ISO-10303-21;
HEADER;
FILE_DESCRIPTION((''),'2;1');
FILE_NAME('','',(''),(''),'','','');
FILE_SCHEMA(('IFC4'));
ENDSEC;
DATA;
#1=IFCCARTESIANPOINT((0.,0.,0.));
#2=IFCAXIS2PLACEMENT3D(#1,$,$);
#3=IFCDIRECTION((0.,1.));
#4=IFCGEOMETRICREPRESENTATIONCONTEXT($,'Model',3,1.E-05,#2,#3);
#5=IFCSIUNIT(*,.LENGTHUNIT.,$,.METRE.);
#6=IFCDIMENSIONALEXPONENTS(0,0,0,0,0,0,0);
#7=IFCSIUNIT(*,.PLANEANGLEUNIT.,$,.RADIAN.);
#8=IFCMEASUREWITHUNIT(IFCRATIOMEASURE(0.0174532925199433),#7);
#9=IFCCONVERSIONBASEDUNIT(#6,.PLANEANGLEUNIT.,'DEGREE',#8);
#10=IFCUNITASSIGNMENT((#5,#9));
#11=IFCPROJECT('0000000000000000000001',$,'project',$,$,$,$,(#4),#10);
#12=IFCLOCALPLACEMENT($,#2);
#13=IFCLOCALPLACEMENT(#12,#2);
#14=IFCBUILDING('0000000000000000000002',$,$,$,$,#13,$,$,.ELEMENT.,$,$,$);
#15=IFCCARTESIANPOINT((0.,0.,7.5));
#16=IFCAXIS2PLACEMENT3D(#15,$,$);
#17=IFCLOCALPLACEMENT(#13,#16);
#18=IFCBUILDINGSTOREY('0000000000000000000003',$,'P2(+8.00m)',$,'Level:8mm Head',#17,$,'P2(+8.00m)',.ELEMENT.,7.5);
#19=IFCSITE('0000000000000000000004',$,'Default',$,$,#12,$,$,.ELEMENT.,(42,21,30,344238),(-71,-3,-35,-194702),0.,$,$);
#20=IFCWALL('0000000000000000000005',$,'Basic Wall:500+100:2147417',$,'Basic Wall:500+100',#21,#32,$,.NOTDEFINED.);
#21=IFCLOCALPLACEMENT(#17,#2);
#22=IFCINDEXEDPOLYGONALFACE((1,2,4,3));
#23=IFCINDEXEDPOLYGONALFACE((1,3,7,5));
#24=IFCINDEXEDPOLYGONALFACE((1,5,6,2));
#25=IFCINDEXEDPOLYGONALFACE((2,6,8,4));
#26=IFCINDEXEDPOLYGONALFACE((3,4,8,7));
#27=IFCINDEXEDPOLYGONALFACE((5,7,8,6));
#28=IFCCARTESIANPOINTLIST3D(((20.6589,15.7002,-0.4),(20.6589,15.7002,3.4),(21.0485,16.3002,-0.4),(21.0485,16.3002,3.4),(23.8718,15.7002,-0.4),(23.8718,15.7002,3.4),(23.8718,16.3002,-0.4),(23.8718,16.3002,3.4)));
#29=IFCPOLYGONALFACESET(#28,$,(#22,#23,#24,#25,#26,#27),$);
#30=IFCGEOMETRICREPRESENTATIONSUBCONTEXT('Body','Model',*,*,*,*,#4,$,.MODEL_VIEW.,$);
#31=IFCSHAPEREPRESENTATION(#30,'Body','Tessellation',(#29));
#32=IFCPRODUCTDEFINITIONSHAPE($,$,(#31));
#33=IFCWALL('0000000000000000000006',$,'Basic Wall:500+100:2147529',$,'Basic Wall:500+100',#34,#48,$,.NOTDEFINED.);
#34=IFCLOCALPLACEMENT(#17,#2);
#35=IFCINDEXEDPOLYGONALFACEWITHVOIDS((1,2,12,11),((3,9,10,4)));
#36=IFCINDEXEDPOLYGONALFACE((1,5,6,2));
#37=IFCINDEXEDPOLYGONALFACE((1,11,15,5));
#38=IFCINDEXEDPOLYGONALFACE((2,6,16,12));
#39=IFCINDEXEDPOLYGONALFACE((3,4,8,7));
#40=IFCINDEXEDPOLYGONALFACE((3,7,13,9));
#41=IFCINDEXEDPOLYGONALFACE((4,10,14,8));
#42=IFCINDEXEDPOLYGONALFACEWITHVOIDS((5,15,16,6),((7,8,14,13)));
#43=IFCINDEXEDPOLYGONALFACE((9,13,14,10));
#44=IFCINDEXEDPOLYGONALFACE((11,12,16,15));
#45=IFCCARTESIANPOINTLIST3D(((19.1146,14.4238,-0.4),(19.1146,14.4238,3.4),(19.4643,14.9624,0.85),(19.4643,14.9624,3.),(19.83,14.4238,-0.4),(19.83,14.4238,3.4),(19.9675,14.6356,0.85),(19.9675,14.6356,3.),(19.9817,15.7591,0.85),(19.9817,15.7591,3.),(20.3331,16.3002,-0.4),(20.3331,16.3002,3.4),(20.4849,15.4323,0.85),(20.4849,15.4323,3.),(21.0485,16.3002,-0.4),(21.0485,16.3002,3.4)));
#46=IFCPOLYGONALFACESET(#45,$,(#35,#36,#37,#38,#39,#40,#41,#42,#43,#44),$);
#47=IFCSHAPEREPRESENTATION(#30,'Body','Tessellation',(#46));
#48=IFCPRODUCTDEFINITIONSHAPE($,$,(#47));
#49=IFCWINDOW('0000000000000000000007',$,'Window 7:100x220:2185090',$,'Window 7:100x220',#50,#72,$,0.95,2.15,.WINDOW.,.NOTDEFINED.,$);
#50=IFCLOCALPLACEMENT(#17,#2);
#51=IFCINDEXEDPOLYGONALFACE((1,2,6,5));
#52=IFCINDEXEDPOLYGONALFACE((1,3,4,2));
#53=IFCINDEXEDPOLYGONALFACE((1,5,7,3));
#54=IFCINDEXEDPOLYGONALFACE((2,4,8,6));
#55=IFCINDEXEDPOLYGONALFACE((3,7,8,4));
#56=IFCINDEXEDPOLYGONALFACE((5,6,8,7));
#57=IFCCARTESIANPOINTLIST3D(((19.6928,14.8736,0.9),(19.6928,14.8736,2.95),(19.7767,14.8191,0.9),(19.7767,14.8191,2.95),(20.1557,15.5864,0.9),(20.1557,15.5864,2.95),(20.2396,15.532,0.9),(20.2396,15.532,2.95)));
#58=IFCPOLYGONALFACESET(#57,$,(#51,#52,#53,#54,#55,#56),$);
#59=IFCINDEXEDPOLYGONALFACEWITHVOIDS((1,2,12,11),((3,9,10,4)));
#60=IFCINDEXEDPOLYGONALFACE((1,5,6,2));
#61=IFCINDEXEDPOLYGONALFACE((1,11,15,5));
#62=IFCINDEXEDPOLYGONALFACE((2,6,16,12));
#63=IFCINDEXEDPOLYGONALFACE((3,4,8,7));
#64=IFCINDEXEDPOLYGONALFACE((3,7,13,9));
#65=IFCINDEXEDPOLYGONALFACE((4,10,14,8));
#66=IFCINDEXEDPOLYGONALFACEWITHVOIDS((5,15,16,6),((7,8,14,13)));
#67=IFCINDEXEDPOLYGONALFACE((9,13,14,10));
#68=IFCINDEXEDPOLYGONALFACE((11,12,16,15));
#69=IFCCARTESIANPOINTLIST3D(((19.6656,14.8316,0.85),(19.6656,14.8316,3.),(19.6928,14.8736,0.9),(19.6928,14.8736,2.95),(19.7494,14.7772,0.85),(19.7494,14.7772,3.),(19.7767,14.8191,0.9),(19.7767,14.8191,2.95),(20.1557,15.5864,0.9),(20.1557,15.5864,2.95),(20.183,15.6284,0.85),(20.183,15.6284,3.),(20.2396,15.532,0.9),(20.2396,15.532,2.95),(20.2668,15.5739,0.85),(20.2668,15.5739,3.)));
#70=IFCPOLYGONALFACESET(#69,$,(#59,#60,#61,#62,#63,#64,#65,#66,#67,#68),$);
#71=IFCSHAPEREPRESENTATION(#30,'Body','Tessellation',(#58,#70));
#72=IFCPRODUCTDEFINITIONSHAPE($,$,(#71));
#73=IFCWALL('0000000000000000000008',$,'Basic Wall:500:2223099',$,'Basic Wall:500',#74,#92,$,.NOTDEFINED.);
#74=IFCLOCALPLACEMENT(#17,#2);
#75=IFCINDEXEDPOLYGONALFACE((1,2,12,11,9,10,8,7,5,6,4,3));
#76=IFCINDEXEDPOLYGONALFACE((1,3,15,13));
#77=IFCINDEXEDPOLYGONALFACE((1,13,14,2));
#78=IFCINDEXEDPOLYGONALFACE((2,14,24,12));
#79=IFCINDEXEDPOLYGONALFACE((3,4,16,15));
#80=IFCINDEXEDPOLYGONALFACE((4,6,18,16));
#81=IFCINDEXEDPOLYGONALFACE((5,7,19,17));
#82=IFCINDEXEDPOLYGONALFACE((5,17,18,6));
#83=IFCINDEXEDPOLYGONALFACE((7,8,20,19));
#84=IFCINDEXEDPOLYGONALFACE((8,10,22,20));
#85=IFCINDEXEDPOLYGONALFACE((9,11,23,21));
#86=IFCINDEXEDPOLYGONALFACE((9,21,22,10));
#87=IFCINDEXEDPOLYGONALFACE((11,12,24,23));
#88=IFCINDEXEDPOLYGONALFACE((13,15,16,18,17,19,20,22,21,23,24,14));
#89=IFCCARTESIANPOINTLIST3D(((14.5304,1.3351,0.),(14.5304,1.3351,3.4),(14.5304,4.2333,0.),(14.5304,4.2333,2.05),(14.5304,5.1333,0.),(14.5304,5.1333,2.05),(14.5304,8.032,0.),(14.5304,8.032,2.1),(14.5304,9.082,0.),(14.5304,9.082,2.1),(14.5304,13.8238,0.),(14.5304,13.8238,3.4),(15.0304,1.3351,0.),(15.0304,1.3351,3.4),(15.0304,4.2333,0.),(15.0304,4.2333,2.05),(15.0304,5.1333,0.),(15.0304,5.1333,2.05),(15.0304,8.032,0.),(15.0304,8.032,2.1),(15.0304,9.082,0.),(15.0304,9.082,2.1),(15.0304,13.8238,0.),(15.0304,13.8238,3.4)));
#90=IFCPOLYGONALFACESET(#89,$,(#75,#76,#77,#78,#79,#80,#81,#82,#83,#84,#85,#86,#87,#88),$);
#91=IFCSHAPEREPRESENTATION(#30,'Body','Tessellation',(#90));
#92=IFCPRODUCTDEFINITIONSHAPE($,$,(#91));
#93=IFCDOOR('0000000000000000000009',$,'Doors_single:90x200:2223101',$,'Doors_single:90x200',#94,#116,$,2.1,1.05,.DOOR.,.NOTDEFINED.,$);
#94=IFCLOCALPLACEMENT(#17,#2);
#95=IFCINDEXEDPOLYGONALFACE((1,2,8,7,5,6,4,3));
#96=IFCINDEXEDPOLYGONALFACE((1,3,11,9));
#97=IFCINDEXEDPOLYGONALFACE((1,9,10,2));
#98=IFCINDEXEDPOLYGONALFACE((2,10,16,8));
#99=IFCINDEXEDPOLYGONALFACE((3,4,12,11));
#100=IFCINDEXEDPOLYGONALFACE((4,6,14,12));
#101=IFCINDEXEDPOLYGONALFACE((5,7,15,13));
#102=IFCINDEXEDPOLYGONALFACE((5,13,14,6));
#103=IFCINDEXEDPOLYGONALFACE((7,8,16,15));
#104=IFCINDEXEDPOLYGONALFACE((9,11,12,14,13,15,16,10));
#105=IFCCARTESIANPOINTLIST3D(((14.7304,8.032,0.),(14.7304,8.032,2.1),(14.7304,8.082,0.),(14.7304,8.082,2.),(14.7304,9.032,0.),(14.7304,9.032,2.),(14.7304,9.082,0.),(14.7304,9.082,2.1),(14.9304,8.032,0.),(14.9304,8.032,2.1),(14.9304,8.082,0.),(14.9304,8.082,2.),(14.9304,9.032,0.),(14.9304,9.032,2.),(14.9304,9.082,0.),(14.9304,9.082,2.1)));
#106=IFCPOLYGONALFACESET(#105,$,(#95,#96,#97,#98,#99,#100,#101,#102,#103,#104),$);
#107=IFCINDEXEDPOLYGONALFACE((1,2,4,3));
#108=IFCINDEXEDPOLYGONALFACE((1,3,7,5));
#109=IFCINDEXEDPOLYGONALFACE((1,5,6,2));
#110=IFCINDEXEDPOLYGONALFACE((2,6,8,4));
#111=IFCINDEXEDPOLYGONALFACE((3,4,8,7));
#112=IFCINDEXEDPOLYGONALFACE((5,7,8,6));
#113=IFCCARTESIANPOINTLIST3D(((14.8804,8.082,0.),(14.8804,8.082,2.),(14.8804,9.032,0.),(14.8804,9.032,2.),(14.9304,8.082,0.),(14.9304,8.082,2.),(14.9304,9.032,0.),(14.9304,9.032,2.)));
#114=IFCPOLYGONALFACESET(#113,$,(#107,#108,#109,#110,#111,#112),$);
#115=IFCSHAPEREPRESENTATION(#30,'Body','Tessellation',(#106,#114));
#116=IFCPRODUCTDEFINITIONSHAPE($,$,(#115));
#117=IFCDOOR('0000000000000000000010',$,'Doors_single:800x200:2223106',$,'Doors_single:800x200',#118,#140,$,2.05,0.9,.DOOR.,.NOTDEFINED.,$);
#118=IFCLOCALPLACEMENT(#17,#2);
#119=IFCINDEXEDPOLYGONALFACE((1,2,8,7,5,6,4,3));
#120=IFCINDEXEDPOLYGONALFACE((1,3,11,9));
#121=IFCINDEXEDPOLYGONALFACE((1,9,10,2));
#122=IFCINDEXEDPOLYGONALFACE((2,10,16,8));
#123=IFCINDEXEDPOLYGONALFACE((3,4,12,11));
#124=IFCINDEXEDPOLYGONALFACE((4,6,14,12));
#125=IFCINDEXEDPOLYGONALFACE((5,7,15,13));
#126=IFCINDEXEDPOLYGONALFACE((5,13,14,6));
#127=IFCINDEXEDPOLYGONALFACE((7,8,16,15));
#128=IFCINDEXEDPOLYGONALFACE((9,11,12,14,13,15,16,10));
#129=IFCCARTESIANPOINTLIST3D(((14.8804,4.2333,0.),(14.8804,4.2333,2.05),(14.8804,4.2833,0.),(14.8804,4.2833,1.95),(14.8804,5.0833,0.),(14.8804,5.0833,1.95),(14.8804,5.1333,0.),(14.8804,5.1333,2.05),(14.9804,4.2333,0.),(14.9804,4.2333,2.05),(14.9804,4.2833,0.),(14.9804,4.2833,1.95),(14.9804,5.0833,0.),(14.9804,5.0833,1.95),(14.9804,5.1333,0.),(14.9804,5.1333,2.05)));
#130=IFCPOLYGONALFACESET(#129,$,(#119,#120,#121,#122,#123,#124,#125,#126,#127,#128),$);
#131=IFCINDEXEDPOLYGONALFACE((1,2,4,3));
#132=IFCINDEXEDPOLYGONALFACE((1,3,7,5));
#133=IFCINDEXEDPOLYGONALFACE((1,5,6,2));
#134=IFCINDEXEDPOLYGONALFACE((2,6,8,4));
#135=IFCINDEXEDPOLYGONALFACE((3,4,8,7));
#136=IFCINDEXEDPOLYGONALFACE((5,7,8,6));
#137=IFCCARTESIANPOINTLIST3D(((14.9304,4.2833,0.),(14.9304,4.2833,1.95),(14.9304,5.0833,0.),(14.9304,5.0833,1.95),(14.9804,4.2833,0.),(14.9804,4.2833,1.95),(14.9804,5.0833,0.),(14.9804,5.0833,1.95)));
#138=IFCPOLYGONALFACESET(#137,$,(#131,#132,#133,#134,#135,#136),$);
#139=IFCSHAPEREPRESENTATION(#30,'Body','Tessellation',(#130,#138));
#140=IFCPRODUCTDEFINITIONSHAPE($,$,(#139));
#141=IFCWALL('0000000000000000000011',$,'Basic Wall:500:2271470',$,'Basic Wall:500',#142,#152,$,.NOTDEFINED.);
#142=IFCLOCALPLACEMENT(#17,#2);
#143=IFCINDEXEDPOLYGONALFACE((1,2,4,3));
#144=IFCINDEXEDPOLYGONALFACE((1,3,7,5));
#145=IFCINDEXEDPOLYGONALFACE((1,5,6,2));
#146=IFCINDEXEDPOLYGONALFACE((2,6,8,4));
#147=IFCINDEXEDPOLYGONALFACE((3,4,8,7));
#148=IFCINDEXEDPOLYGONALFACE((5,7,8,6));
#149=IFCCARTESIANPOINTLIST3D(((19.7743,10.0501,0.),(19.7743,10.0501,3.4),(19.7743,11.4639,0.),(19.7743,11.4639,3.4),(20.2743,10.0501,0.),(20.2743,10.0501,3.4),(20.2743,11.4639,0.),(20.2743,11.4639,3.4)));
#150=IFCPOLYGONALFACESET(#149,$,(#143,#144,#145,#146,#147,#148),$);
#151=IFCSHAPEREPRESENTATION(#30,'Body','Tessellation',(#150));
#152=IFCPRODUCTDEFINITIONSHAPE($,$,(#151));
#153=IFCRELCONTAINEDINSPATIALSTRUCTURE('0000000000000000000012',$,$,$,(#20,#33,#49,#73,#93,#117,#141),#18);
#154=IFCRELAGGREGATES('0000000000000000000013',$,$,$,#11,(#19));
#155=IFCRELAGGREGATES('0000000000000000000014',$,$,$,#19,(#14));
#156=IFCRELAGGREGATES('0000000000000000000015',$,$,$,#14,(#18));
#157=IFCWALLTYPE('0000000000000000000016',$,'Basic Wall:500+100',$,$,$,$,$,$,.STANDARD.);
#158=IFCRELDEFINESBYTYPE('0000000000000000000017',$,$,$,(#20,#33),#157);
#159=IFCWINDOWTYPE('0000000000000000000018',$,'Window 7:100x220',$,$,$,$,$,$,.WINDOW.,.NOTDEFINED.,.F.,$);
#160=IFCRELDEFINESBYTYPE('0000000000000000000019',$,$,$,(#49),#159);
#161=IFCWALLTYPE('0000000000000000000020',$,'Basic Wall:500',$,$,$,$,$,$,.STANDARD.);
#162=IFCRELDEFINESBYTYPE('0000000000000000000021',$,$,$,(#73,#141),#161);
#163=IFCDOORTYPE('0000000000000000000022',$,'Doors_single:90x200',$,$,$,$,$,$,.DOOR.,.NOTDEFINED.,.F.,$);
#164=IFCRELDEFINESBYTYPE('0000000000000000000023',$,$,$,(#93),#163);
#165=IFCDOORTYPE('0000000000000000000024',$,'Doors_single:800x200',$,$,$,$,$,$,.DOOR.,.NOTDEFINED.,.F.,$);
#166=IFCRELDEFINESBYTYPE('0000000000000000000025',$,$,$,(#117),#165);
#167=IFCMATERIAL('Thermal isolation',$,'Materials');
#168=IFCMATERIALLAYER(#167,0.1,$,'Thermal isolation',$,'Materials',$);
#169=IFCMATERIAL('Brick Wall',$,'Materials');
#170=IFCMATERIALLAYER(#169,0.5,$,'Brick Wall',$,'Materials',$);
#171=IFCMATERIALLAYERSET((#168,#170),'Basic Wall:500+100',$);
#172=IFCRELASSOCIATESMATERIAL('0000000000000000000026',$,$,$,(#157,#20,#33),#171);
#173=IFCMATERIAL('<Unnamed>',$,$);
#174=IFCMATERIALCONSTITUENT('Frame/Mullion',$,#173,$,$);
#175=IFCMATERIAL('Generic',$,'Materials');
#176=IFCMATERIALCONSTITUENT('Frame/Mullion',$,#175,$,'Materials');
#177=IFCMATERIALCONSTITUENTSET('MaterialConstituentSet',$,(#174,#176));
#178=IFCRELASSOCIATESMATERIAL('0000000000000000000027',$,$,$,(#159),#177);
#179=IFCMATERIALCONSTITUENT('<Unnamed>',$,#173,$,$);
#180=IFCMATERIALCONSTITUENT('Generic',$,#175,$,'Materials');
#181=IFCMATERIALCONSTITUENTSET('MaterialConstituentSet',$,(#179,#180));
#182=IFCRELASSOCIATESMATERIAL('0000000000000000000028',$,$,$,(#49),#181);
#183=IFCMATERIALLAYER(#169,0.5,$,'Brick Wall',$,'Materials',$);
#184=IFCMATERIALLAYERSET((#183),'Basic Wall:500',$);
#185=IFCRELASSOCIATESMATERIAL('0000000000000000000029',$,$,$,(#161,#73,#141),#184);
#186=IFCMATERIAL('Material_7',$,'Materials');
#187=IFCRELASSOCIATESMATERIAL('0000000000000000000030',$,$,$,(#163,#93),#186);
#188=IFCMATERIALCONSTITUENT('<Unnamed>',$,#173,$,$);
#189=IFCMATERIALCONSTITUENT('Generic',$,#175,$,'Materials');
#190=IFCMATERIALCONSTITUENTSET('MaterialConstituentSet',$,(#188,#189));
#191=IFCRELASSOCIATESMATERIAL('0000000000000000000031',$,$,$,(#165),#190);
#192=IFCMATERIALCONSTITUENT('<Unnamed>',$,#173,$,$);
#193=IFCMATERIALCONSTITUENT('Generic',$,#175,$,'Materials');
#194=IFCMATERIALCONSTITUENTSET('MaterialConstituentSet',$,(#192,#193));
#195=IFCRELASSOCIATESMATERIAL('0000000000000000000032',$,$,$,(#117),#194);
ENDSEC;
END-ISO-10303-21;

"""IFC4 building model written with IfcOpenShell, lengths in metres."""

from ifc_helpers import new_model, entity, si_unit, converted_unit, direction, frame, frame_2d, origin, origin_2d_with_axis, place, context, subcontext, project, spatial, polyline, rectangle, outline, extrude, source, transform, mapped, material, layer, layer_set, layer_usage, constituent, constituent_set, type_object, type_shapes, element, fill, save


model = new_model("IFC4")

# Units and contexts
model_context = context("Model", 3, precision=1e-05, world=origin(), true_north=direction((0.0, 1.0)))
body_context = subcontext(model_context, "Body", "Model", "MODEL_VIEW")
ifc_project = project(units=[si_unit("LENGTHUNIT", "METRE"), converted_unit("PLANEANGLEUNIT", "DEGREE", entity("IfcRatioMeasure", 0.0174532925199433), si_unit("PLANEANGLEUNIT", "RADIAN"), dimensions=[0, 0, 0, 0, 0, 0, 0])], contexts=[model_context])

# Site, building, storey
site_placement = place(None, origin())
site = spatial("IfcSite", under=ifc_project, at=site_placement, Name="Default", CompositionType="ELEMENT", RefLatitude=(42, 21, 30, 344238), RefLongitude=(-71, -3, -35, -194702), RefElevation=0.0)
building_placement = place(site_placement, origin())
building = spatial("IfcBuilding", under=site, at=building_placement, CompositionType="ELEMENT")
storey_placement = place(building_placement, frame((0.0, 0.0, 7.5)))
storey = spatial("IfcBuildingStorey", under=building, at=storey_placement, Name="P2(+8.00m)", ObjectType="Level:8mm Head", LongName="P2(+8.00m)", CompositionType="ELEMENT", Elevation=7.5)

# Wall
ifc_material_1 = material(Name="Thermal isolation", Category="Materials")
ifc_layer_1 = layer(ifc_material_1, 0.1, Name="Thermal isolation", Category="Materials")
ifc_material_2 = material(Name="Brick Wall", Category="Materials")
ifc_layer_2 = layer(ifc_material_2, 0.5, Name="Brick Wall", Category="Materials")
ifc_layer_set_1 = layer_set([ifc_layer_1, ifc_layer_2], Name="Basic Wall:500+100")
ifc_layer_usage_1 = layer_usage(ifc_layer_set_1, "AXIS2", "POSITIVE", -0.3)
wall_type_1 = type_object("IfcWallType", Name="Basic Wall:500+100", PredefinedType="STANDARD", material=ifc_layer_set_1)
wall_1_placement = place(storey_placement, frame((23.8718, 16.0002, -0.4), z_axis=(0.0, 0.0, 1.0), x_axis=(-1.0, 0.0, 0.0)))
element("IfcWall", 1, at=wall_1_placement, inside=storey, type_object=wall_type_1, material=ifc_layer_usage_1, Name="Basic Wall:500+100:2147417", ObjectType="Basic Wall:500+100", PredefinedType="NOTDEFINED", context=body_context, shape_type="SweptSolid", body=[
    extrude(outline(polyline([(2.8233, -0.3), (3.213, 0.3), (0.0, 0.3), (0.0, -0.3), (2.8233, -0.3)])), origin(), (0.0, 0.0, 1.0), 3.8),
])

# Wall, opening, window
ifc_layer_usage_2 = layer_usage(ifc_layer_set_1, "AXIS2", "NEGATIVE", 0.3)
wall_2_placement = place(storey_placement, frame((19.3662, 14.2604, -0.4), z_axis=(0.0, 0.0, 1.0), x_axis=(0.544639, 0.838671, 0.0)))
wall_2 = element("IfcWall", 2, at=wall_2_placement, inside=storey, type_object=wall_type_1, material=ifc_layer_usage_2, Name="Basic Wall:500+100:2147529", ObjectType="Basic Wall:500+100", PredefinedType="NOTDEFINED", context=body_context, shape_type="SweptSolid", body=[
    extrude(outline(polyline([(2.627, -0.3), (2.2373, 0.3), (0.0, 0.3), (0.3896, -0.3), (1.9115, -0.3), (2.627, -0.3)])), origin(), (0.0, 0.0, 1.0), 3.8),
])
opening_1_placement = place(wall_2_placement, frame((0.0702, 0.3278, 1.25), z_axis=(0.0, 0.0, 1.0), x_axis=(0.544639, -0.838671, 0.0)))
opening_1 = element("IfcOpeningElement", 3, at=opening_1_placement, cuts=wall_2, PredefinedType="OPENING", context=body_context, shape_type="SweptSolid", body=[
    extrude(rectangle(XDim=2.15, YDim=0.95, at=frame_2d((0.0, 0.0), x_axis=(1.0, 0.0))), frame((1.3087, 0.3984, 1.075), z_axis=(-0.838671, 0.544639, 0.0), x_axis=(0.0, 0.0, -1.0)), (0.0, 0.0, 1.0), 1.252),
])
ifc_material_3 = material(Name="<Unnamed>")
ifc_constituent_1 = constituent(ifc_material_3, Name="<Unnamed>")
ifc_material_4 = material(Name="Generic", Category="Materials")
ifc_constituent_2 = constituent(ifc_material_4, Name="Generic", Category="Materials")
ifc_constituent_set_1 = constituent_set(constituents=[ifc_constituent_1, ifc_constituent_2], Name="MaterialConstituentSet")
ifc_constituent_3 = constituent(ifc_material_3, Name="Frame/Mullion")
ifc_constituent_4 = constituent(ifc_material_4, Name="Frame/Mullion", Category="Materials")
ifc_constituent_set_2 = constituent_set(constituents=[ifc_constituent_3, ifc_constituent_4], Name="MaterialConstituentSet")
window_type = type_object("IfcWindowType", Name="Window 7:100x220", ParameterTakesPrecedence=False, PartitioningType="NOTDEFINED", PredefinedType="WINDOW", material=ifc_constituent_set_2)
shared_shape_1 = source(origin(), body_context, "Body", "SweptSolid", [
    extrude(rectangle(XDim=0.1, YDim=0.85, at=origin_2d_with_axis()), frame((0.475, -0.6891, 0.05), z_axis=(0.0, 0.0, 1.0), x_axis=(0.0, 1.0, 0.0)), (0.0, 0.0, 1.0), 2.05),
    extrude(outline(polyline([(-0.475, -1.075), (0.475, -1.075), (0.475, 1.075), (-0.475, 1.075), (-0.475, -1.075)]), holes=[polyline([(-0.425, -1.025), (-0.425, 1.025), (0.425, 1.025), (0.425, -1.025), (-0.425, -1.025)])]), frame((0.475, -0.7391, 1.075), z_axis=(0.0, 1.0, 0.0), x_axis=(1.0, 0.0, 0.0)), (0.0, 0.0, 1.0), 0.1),
])
type_shapes(window_type, [shared_shape_1])
window_placement = place(opening_1_placement, frame((0.0, 0.6819, 0.0), z_axis=(0.0, 0.0, 1.0), x_axis=(0.544639, 0.838671, 0.0)))
window = element("IfcWindow", 4, at=window_placement, inside=storey, type_object=window_type, material=ifc_constituent_set_1, Name="Window 7:100x220:2185090", ObjectType="Window 7:100x220", OverallHeight=0.95, OverallWidth=2.15, PartitioningType="NOTDEFINED", PredefinedType="WINDOW", context=body_context, shape_type="MappedRepresentation", body=[
    mapped(shared_shape_1, transform((0.0, 0.0, 0.0), scale=1.0)),
])
fill(opening_1, window)

# Wall, openings, doors
ifc_layer_3 = layer(ifc_material_2, 0.5, Name="Brick Wall", Category="Materials")
ifc_layer_set_2 = layer_set([ifc_layer_3], Name="Basic Wall:500")
ifc_layer_usage_3 = layer_usage(ifc_layer_set_2, "AXIS2", "POSITIVE", -0.25)
wall_type_2 = type_object("IfcWallType", Name="Basic Wall:500", PredefinedType="STANDARD", material=ifc_layer_set_2)
wall_3_placement = place(storey_placement, frame((14.7804, 13.8238, 0.0), z_axis=(0.0, 0.0, 1.0), x_axis=(0.0, -1.0, 0.0)))
wall_3 = element("IfcWall", 5, at=wall_3_placement, inside=storey, type_object=wall_type_2, material=ifc_layer_usage_3, Name="Basic Wall:500:2223099", ObjectType="Basic Wall:500", PredefinedType="NOTDEFINED", context=body_context, shape_type="SweptSolid", body=[
    extrude(rectangle(XDim=12.4888, YDim=0.5, at=frame_2d((6.2444, 0.0), x_axis=(-1.0, 0.0))), origin(), (0.0, 0.0, 1.0), 3.4),
])
opening_2_placement = place(wall_3_placement, frame((8.6906, -0.25, 0.0)))
opening_2 = element("IfcOpeningElement", 6, at=opening_2_placement, cuts=wall_3, PredefinedType="OPENING", context=body_context, shape_type="SweptSolid", body=[
    extrude(rectangle(XDim=2.05, YDim=0.9, at=frame_2d((1.025, 0.45), x_axis=(1.0, 0.0))), frame((0.0, 0.0, 0.0), z_axis=(0.0, 1.0, 0.0), x_axis=(0.0, 0.0, 1.0)), (0.0, 0.0, 1.0), 0.5),
])
opening_3_placement = place(wall_3_placement, frame((4.7418, -0.25, 0.0)))
opening_3 = element("IfcOpeningElement", 7, at=opening_3_placement, cuts=wall_3, PredefinedType="OPENING", context=body_context, shape_type="SweptSolid", body=[
    extrude(rectangle(XDim=2.1, YDim=1.05, at=frame_2d((1.05, 0.525), x_axis=(1.0, 0.0))), frame((0.0, 0.0, 0.0), z_axis=(0.0, 1.0, 0.0), x_axis=(0.0, 0.0, 1.0)), (0.0, 0.0, 1.0), 0.5),
])
ifc_material_5 = material(Name="Material_7", Category="Materials")
door_type_1 = type_object("IfcDoorType", Name="Doors_single:90x200", OperationType="NOTDEFINED", ParameterTakesPrecedence=False, PredefinedType="DOOR", material=ifc_material_5)
shared_shape_2 = source(origin(), body_context, "Body", "SweptSolid", [
    extrude(outline(polyline([(-0.525, -1.025), (-0.475, -1.025), (-0.475, 0.975), (0.475, 0.975), (0.475, -1.025), (0.525, -1.025), (0.525, 1.075), (-0.525, 1.075), (-0.525, -1.025)])), frame((0.525, 0.4, 1.025), z_axis=(0.0, -1.0, 0.0), x_axis=(1.0, 0.0, 0.0)), (0.0, 0.0, 1.0), 0.2),
    extrude(rectangle(XDim=0.05, YDim=0.95, at=origin_2d_with_axis()), frame((0.525, 0.375, 0.0), z_axis=(0.0, 0.0, 1.0), x_axis=(0.0, -1.0, 0.0)), (0.0, 0.0, 1.0), 2.0),
])
type_shapes(door_type_1, [shared_shape_2])
door_1_placement = place(opening_3_placement, origin())
door_1 = element("IfcDoor", 8, at=door_1_placement, inside=storey, type_object=door_type_1, material=ifc_material_5, Name="Doors_single:90x200:2223101", ObjectType="Doors_single:90x200", OperationType="NOTDEFINED", OverallHeight=2.1, OverallWidth=1.05, PredefinedType="DOOR", context=body_context, shape_type="MappedRepresentation", body=[
    mapped(shared_shape_2, transform((0.0, 0.0, 0.0), scale=1.0)),
])
fill(opening_3, door_1)
ifc_constituent_5 = constituent(ifc_material_3, Name="<Unnamed>")
ifc_constituent_6 = constituent(ifc_material_4, Name="Generic", Category="Materials")
ifc_constituent_set_3 = constituent_set(constituents=[ifc_constituent_5, ifc_constituent_6], Name="MaterialConstituentSet")
ifc_constituent_7 = constituent(ifc_material_3, Name="<Unnamed>")
ifc_constituent_8 = constituent(ifc_material_4, Name="Generic", Category="Materials")
ifc_constituent_set_4 = constituent_set(constituents=[ifc_constituent_7, ifc_constituent_8], Name="MaterialConstituentSet")
door_type_2 = type_object("IfcDoorType", Name="Doors_single:800x200", OperationType="NOTDEFINED", ParameterTakesPrecedence=False, PredefinedType="DOOR", material=ifc_constituent_set_4)
shared_shape_3 = source(origin(), body_context, "Body", "SweptSolid", [
    extrude(outline(polyline([(-0.45, -1.0), (-0.4, -1.0), (-0.4, 0.95), (0.4, 0.95), (0.4, -1.0), (0.45, -1.0), (0.45, 1.05), (-0.45, 1.05), (-0.45, -1.0)])), frame((0.45, 0.35, 1.0), z_axis=(0.0, 1.0, 0.0), x_axis=(-1.0, 0.0, 0.0)), (0.0, 0.0, 1.0), 0.1),
    extrude(rectangle(XDim=0.8, YDim=0.05, at=origin_2d_with_axis()), frame((0.45, 0.425, 0.0), z_axis=(0.0, 0.0, 1.0), x_axis=(-1.0, 0.0, 0.0)), (0.0, 0.0, 1.0), 1.95),
])
type_shapes(door_type_2, [shared_shape_3])
door_2_placement = place(opening_2_placement, origin())
door_2 = element("IfcDoor", 9, at=door_2_placement, inside=storey, type_object=door_type_2, material=ifc_constituent_set_3, Name="Doors_single:800x200:2223106", ObjectType="Doors_single:800x200", OperationType="NOTDEFINED", OverallHeight=2.05, OverallWidth=0.9, PredefinedType="DOOR", context=body_context, shape_type="MappedRepresentation", body=[
    mapped(shared_shape_3, transform((0.0, 0.0, 0.0), scale=1.0)),
])
fill(opening_2, door_2)

# Wall
ifc_layer_usage_4 = layer_usage(ifc_layer_set_2, "AXIS2", "NEGATIVE", 0.25)
wall_4_placement = place(storey_placement, frame((20.0243, 11.4639, 0.0), z_axis=(0.0, 0.0, 1.0), x_axis=(0.0, -1.0, 0.0)))
element("IfcWall", 10, at=wall_4_placement, inside=storey, type_object=wall_type_2, material=ifc_layer_usage_4, Name="Basic Wall:500:2271470", ObjectType="Basic Wall:500", PredefinedType="NOTDEFINED", context=body_context, shape_type="SweptSolid", body=[
    extrude(rectangle(XDim=1.4139, YDim=0.5, at=frame_2d((0.7069, 0.0), x_axis=(-1.0, 0.0))), origin(), (0.0, 0.0, 1.0), 3.4),
])

save(model, "model.ifc")
